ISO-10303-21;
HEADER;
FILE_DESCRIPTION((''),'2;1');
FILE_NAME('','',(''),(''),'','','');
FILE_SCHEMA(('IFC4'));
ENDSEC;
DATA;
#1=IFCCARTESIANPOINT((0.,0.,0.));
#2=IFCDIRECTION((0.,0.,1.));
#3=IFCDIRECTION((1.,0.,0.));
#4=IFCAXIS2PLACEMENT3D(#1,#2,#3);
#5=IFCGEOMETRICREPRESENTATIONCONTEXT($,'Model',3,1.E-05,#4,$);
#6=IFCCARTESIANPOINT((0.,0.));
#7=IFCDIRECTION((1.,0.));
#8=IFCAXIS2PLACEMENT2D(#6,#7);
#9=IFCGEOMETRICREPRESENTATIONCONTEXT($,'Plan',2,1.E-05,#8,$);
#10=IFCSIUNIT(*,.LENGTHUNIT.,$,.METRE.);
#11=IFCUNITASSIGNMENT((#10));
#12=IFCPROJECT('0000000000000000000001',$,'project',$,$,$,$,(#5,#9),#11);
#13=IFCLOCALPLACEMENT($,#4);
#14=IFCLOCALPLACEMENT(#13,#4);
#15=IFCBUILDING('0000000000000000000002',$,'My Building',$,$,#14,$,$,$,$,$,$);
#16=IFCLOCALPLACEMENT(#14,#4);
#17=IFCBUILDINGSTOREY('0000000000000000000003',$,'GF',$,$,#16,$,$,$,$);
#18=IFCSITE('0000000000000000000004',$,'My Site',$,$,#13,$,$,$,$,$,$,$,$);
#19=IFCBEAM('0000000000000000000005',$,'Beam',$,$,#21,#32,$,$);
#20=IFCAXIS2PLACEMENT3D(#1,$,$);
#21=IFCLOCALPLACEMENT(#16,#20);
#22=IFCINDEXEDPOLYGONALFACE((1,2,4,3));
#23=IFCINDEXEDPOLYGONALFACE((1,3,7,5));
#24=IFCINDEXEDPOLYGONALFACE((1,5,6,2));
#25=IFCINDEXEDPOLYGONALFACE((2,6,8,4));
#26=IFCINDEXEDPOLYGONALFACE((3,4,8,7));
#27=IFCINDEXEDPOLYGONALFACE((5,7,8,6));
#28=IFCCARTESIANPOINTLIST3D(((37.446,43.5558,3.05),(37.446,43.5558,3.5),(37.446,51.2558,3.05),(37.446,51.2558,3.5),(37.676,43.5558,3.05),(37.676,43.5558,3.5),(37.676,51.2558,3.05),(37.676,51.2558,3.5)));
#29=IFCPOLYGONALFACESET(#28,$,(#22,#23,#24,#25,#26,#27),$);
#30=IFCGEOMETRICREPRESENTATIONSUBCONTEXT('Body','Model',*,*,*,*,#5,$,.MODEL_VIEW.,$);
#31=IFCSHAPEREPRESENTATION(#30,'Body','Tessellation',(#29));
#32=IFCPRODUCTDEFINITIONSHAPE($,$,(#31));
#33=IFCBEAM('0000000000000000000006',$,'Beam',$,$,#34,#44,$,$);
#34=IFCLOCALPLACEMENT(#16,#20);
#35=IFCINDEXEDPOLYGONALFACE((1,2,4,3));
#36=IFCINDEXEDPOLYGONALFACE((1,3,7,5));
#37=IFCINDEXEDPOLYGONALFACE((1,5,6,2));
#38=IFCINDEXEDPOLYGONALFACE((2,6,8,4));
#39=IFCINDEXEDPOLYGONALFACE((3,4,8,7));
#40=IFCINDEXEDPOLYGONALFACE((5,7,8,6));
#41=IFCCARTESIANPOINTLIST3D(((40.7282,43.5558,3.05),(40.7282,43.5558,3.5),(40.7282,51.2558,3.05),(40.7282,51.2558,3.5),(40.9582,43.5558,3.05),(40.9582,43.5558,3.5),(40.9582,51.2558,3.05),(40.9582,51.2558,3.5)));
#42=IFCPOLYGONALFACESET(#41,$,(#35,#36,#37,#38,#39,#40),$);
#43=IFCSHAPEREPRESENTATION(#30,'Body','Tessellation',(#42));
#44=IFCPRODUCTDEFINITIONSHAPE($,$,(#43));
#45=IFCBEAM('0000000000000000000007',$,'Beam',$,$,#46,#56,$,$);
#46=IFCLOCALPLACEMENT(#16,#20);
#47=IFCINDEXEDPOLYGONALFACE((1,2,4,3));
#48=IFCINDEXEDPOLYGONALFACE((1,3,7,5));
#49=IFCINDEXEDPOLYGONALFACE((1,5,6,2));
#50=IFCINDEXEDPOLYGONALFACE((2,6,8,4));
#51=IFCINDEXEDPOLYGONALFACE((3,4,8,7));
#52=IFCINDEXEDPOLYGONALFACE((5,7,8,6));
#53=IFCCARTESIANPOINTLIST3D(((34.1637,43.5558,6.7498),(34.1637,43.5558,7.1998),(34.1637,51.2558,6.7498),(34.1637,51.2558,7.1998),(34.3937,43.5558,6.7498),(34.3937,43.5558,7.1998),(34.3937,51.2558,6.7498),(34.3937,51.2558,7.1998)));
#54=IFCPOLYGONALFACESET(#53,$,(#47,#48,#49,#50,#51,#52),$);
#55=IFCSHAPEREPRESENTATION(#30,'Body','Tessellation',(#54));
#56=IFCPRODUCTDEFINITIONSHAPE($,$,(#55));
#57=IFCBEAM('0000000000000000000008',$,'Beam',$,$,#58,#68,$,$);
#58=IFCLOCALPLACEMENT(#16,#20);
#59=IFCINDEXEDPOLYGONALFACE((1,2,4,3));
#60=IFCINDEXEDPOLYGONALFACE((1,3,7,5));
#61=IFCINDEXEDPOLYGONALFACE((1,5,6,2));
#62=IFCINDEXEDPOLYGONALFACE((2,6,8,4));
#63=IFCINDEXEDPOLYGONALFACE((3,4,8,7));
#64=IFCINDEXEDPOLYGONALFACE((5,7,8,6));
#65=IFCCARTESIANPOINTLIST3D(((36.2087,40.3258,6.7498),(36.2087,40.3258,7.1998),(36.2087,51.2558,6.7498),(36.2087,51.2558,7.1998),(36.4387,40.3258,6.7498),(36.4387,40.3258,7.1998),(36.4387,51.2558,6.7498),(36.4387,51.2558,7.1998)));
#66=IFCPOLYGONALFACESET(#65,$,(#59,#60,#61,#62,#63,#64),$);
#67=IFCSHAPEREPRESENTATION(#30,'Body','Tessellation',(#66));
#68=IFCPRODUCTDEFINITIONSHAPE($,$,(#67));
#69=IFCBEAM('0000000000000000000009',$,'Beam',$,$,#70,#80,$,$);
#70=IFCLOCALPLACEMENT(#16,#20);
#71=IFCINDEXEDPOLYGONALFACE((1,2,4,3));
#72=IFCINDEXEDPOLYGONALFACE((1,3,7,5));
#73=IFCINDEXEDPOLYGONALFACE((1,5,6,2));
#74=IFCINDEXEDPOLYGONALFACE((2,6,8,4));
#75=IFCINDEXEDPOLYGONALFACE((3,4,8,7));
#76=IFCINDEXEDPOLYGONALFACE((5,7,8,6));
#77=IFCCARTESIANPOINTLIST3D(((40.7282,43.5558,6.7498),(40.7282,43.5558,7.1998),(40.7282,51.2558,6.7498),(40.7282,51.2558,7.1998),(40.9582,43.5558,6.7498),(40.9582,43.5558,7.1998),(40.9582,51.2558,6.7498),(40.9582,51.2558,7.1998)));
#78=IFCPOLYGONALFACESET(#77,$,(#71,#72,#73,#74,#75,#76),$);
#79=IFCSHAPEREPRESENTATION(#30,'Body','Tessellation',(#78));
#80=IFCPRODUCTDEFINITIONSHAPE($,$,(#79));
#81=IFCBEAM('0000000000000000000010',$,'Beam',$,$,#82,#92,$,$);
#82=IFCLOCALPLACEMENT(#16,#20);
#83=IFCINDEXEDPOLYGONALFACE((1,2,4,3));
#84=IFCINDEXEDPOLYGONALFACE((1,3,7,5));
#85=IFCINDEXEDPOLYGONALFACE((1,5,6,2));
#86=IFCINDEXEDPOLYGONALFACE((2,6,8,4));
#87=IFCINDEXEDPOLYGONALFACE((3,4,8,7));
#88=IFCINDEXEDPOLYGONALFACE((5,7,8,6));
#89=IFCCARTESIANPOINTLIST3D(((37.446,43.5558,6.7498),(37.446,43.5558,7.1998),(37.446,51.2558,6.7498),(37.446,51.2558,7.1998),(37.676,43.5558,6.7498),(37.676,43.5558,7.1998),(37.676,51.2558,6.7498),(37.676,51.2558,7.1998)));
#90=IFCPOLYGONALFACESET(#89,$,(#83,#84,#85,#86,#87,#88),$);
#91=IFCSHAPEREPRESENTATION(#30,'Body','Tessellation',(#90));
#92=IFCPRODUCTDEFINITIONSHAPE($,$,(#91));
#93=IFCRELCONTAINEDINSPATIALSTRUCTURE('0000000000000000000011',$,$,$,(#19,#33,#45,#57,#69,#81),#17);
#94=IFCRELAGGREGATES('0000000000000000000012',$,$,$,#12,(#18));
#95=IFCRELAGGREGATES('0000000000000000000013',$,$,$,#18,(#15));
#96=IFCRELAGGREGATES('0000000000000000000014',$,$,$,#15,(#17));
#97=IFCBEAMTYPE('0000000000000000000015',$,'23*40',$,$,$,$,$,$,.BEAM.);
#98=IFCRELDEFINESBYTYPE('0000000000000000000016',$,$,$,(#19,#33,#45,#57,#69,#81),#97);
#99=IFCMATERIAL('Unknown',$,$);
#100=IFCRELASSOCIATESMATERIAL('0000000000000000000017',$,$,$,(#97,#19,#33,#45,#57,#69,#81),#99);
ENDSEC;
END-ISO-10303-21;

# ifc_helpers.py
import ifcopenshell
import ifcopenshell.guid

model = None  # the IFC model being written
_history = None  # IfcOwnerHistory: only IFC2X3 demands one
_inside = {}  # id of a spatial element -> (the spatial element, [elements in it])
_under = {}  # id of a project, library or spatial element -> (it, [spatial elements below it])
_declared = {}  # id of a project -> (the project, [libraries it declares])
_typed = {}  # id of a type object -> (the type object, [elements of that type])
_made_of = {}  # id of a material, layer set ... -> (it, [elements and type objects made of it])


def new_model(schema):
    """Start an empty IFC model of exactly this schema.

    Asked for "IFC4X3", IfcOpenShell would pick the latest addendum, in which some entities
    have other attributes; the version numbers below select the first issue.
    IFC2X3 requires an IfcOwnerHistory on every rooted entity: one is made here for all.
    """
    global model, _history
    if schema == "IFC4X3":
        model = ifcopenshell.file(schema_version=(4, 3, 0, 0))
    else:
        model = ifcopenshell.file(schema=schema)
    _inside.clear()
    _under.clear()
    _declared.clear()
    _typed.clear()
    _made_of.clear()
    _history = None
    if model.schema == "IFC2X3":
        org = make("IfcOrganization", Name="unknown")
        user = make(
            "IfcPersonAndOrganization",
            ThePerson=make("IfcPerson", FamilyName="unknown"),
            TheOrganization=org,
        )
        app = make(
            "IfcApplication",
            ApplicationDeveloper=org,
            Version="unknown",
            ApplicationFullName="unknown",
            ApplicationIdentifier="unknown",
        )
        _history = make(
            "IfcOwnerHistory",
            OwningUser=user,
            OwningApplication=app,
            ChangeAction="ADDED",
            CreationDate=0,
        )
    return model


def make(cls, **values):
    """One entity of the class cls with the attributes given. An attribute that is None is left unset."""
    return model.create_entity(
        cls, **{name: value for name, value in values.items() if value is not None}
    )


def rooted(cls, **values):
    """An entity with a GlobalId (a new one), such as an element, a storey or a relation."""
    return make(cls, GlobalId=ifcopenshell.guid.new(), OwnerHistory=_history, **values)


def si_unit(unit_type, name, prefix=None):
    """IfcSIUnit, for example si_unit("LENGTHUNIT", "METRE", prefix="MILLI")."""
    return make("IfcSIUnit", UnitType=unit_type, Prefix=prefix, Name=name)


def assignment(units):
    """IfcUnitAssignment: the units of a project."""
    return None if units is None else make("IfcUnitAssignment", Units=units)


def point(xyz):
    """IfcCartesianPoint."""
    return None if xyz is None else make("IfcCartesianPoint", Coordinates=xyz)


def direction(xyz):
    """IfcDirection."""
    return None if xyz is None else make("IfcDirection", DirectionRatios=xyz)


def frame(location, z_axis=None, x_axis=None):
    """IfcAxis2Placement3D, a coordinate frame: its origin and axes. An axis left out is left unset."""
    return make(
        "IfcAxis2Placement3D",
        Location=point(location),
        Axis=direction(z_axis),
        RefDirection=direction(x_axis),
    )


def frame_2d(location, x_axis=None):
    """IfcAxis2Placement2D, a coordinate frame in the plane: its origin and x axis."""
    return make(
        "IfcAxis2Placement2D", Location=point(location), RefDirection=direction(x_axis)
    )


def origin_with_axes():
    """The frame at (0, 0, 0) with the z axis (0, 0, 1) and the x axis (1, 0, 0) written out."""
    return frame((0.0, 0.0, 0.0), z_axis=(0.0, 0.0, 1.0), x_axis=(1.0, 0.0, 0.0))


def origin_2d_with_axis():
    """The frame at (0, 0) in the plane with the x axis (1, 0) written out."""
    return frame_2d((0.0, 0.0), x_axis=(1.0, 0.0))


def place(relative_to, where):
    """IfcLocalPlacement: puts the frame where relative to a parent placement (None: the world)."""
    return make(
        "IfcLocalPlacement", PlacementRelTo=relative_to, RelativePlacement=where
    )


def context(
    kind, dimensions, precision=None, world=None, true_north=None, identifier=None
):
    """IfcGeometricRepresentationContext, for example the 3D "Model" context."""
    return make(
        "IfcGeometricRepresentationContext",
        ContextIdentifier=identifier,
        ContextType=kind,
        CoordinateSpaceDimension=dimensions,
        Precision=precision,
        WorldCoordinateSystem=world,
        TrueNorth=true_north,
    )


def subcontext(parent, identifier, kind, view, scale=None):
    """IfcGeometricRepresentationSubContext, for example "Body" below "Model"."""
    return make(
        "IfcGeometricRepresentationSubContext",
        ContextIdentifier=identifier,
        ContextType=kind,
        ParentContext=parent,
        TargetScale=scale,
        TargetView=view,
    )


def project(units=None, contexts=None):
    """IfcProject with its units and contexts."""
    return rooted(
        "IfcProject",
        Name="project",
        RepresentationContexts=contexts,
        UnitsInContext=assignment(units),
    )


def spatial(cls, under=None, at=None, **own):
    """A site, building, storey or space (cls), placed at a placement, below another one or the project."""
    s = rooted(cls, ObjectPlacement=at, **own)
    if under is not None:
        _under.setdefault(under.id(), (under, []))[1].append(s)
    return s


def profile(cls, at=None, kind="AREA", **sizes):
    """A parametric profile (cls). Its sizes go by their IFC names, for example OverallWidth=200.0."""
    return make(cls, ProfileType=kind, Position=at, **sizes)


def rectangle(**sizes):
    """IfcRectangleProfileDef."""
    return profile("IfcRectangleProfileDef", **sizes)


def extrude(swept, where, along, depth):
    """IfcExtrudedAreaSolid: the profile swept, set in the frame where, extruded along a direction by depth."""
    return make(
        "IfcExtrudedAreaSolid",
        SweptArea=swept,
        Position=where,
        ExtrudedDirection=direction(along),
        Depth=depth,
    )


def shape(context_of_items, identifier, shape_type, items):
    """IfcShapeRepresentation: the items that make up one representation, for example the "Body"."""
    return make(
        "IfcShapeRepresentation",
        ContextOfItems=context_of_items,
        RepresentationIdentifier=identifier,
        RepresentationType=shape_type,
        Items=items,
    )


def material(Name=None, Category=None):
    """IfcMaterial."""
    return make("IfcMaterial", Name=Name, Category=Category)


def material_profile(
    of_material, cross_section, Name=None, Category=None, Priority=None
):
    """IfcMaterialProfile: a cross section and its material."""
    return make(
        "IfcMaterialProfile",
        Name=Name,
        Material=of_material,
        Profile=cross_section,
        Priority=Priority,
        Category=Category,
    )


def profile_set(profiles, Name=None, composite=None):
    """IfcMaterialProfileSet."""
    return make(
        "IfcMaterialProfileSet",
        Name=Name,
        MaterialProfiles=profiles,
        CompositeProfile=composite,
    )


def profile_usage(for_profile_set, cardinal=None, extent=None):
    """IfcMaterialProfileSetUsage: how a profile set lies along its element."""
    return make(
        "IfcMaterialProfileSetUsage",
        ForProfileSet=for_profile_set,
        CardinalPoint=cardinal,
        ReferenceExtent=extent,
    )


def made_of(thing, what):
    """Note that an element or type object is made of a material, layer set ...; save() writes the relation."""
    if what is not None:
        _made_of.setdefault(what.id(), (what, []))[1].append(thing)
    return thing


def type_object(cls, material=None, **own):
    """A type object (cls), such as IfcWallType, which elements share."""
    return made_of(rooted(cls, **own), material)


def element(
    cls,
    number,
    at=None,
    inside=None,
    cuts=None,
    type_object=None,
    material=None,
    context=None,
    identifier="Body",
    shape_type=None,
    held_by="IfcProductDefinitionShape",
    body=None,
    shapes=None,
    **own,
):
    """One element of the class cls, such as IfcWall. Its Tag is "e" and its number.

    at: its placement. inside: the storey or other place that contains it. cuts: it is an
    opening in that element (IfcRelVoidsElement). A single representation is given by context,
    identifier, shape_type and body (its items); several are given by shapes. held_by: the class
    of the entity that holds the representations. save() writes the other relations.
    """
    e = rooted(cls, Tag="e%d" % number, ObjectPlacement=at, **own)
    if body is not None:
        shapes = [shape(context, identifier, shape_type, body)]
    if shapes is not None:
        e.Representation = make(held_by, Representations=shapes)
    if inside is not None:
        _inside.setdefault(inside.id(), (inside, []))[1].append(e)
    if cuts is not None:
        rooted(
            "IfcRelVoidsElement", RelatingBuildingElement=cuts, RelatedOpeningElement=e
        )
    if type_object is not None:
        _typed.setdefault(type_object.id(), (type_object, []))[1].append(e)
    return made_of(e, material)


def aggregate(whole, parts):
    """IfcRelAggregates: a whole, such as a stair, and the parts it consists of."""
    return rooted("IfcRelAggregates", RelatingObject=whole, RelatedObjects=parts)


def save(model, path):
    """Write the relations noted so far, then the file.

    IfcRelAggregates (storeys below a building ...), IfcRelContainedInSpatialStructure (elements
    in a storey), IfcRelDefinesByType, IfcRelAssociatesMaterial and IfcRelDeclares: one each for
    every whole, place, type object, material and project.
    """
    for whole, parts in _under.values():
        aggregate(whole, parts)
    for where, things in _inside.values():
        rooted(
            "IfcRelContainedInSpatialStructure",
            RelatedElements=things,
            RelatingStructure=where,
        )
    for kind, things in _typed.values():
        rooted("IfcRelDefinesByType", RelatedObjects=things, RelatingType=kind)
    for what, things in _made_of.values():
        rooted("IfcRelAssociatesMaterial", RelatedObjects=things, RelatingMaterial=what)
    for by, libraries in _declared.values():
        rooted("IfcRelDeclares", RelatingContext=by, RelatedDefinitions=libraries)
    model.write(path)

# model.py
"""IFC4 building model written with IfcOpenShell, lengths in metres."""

from ifc_helpers import new_model, si_unit, frame, origin_with_axes, origin_2d_with_axis, place, context, subcontext, project, spatial, rectangle, extrude, material, material_profile, profile_set, profile_usage, type_object, element, save


model = new_model("IFC4")

# Units and contexts
model_context = context("Model", 3, precision=1e-05, world=origin_with_axes())
plan_context = context("Plan", 2, precision=1e-05, world=origin_2d_with_axis())
body_context = subcontext(model_context, "Body", "Model", "MODEL_VIEW")
ifc_project = project(units=[si_unit("LENGTHUNIT", "METRE")], contexts=[model_context, plan_context])

# Site, building, storey
site_placement = place(None, origin_with_axes())
site = spatial("IfcSite", under=ifc_project, at=site_placement, Name="My Site")
building_placement = place(site_placement, origin_with_axes())
building = spatial("IfcBuilding", under=site, at=building_placement, Name="My Building")
storey_placement = place(building_placement, origin_with_axes())
storey = spatial("IfcBuildingStorey", under=building, at=storey_placement, Name="GF")

# Shared definitions
ifc_material = material(Name="Unknown")

# Beams
ifc_material_profile_1 = material_profile(ifc_material, rectangle(XDim=0.23, YDim=0.45))
ifc_profile_set_1 = profile_set([ifc_material_profile_1])
beam_type = type_object("IfcBeamType", Name="23*40", PredefinedType="BEAM", material=ifc_profile_set_1)
ifc_profile_usage_1 = profile_usage(ifc_profile_set_1, cardinal=5)
beam_1_placement = place(storey_placement, frame((37.561, 43.5558, 3.275), z_axis=(0.0, 1.0, 0.0), x_axis=(-1.0, 0.0, 0.0)))
element("IfcBeam", 1, at=beam_1_placement, inside=storey, type_object=beam_type, material=ifc_profile_usage_1, Name="Beam", context=body_context, shape_type="SweptSolid", body=[
    extrude(rectangle(XDim=0.23, YDim=0.45), origin_with_axes(), (0.0, 0.0, 1.0), 7.7),
])
ifc_profile_usage_2 = profile_usage(ifc_profile_set_1, cardinal=5)
beam_2_placement = place(storey_placement, frame((40.8432, 43.5558, 3.275), z_axis=(0.0, 1.0, 0.0), x_axis=(-1.0, 0.0, 0.0)))
element("IfcBeam", 2, at=beam_2_placement, inside=storey, type_object=beam_type, material=ifc_profile_usage_2, Name="Beam", context=body_context, shape_type="SweptSolid", body=[
    extrude(rectangle(XDim=0.23, YDim=0.45), origin_with_axes(), (0.0, 0.0, 1.0), 7.7),
])
ifc_profile_usage_3 = profile_usage(ifc_profile_set_1, cardinal=5)
beam_3_placement = place(storey_placement, frame((34.2787, 43.5558, 6.9748), z_axis=(0.0, 1.0, 0.0), x_axis=(-1.0, 0.0, 0.0)))
element("IfcBeam", 3, at=beam_3_placement, inside=storey, type_object=beam_type, material=ifc_profile_usage_3, Name="Beam", context=body_context, shape_type="SweptSolid", body=[
    extrude(rectangle(XDim=0.23, YDim=0.45), origin_with_axes(), (0.0, 0.0, 1.0), 7.7),
])
ifc_profile_usage_4 = profile_usage(ifc_profile_set_1, cardinal=5)
beam_4_placement = place(storey_placement, frame((36.3237, 40.3258, 6.9748), z_axis=(0.0, 1.0, 0.0), x_axis=(-1.0, 0.0, 0.0)))
element("IfcBeam", 4, at=beam_4_placement, inside=storey, type_object=beam_type, material=ifc_profile_usage_4, Name="Beam", context=body_context, shape_type="SweptSolid", body=[
    extrude(rectangle(XDim=0.23, YDim=0.45), origin_with_axes(), (0.0, 0.0, 1.0), 10.93),
])
ifc_profile_usage_5 = profile_usage(ifc_profile_set_1, cardinal=5)
beam_5_placement = place(storey_placement, frame((40.8432, 43.5558, 6.9748), z_axis=(0.0, 1.0, 0.0), x_axis=(-1.0, 0.0, 0.0)))
element("IfcBeam", 5, at=beam_5_placement, inside=storey, type_object=beam_type, material=ifc_profile_usage_5, Name="Beam", context=body_context, shape_type="SweptSolid", body=[
    extrude(rectangle(XDim=0.23, YDim=0.45), origin_with_axes(), (0.0, 0.0, 1.0), 7.7),
])
ifc_profile_usage_6 = profile_usage(ifc_profile_set_1, cardinal=5)
beam_6_placement = place(storey_placement, frame((37.561, 43.5558, 6.9748), z_axis=(0.0, 1.0, 0.0), x_axis=(-1.0, 0.0, 0.0)))
element("IfcBeam", 6, at=beam_6_placement, inside=storey, type_object=beam_type, material=ifc_profile_usage_6, Name="Beam", context=body_context, shape_type="SweptSolid", body=[
    extrude(rectangle(XDim=0.23, YDim=0.45), origin_with_axes(), (0.0, 0.0, 1.0), 7.7),
])

save(model, "model.ifc")
